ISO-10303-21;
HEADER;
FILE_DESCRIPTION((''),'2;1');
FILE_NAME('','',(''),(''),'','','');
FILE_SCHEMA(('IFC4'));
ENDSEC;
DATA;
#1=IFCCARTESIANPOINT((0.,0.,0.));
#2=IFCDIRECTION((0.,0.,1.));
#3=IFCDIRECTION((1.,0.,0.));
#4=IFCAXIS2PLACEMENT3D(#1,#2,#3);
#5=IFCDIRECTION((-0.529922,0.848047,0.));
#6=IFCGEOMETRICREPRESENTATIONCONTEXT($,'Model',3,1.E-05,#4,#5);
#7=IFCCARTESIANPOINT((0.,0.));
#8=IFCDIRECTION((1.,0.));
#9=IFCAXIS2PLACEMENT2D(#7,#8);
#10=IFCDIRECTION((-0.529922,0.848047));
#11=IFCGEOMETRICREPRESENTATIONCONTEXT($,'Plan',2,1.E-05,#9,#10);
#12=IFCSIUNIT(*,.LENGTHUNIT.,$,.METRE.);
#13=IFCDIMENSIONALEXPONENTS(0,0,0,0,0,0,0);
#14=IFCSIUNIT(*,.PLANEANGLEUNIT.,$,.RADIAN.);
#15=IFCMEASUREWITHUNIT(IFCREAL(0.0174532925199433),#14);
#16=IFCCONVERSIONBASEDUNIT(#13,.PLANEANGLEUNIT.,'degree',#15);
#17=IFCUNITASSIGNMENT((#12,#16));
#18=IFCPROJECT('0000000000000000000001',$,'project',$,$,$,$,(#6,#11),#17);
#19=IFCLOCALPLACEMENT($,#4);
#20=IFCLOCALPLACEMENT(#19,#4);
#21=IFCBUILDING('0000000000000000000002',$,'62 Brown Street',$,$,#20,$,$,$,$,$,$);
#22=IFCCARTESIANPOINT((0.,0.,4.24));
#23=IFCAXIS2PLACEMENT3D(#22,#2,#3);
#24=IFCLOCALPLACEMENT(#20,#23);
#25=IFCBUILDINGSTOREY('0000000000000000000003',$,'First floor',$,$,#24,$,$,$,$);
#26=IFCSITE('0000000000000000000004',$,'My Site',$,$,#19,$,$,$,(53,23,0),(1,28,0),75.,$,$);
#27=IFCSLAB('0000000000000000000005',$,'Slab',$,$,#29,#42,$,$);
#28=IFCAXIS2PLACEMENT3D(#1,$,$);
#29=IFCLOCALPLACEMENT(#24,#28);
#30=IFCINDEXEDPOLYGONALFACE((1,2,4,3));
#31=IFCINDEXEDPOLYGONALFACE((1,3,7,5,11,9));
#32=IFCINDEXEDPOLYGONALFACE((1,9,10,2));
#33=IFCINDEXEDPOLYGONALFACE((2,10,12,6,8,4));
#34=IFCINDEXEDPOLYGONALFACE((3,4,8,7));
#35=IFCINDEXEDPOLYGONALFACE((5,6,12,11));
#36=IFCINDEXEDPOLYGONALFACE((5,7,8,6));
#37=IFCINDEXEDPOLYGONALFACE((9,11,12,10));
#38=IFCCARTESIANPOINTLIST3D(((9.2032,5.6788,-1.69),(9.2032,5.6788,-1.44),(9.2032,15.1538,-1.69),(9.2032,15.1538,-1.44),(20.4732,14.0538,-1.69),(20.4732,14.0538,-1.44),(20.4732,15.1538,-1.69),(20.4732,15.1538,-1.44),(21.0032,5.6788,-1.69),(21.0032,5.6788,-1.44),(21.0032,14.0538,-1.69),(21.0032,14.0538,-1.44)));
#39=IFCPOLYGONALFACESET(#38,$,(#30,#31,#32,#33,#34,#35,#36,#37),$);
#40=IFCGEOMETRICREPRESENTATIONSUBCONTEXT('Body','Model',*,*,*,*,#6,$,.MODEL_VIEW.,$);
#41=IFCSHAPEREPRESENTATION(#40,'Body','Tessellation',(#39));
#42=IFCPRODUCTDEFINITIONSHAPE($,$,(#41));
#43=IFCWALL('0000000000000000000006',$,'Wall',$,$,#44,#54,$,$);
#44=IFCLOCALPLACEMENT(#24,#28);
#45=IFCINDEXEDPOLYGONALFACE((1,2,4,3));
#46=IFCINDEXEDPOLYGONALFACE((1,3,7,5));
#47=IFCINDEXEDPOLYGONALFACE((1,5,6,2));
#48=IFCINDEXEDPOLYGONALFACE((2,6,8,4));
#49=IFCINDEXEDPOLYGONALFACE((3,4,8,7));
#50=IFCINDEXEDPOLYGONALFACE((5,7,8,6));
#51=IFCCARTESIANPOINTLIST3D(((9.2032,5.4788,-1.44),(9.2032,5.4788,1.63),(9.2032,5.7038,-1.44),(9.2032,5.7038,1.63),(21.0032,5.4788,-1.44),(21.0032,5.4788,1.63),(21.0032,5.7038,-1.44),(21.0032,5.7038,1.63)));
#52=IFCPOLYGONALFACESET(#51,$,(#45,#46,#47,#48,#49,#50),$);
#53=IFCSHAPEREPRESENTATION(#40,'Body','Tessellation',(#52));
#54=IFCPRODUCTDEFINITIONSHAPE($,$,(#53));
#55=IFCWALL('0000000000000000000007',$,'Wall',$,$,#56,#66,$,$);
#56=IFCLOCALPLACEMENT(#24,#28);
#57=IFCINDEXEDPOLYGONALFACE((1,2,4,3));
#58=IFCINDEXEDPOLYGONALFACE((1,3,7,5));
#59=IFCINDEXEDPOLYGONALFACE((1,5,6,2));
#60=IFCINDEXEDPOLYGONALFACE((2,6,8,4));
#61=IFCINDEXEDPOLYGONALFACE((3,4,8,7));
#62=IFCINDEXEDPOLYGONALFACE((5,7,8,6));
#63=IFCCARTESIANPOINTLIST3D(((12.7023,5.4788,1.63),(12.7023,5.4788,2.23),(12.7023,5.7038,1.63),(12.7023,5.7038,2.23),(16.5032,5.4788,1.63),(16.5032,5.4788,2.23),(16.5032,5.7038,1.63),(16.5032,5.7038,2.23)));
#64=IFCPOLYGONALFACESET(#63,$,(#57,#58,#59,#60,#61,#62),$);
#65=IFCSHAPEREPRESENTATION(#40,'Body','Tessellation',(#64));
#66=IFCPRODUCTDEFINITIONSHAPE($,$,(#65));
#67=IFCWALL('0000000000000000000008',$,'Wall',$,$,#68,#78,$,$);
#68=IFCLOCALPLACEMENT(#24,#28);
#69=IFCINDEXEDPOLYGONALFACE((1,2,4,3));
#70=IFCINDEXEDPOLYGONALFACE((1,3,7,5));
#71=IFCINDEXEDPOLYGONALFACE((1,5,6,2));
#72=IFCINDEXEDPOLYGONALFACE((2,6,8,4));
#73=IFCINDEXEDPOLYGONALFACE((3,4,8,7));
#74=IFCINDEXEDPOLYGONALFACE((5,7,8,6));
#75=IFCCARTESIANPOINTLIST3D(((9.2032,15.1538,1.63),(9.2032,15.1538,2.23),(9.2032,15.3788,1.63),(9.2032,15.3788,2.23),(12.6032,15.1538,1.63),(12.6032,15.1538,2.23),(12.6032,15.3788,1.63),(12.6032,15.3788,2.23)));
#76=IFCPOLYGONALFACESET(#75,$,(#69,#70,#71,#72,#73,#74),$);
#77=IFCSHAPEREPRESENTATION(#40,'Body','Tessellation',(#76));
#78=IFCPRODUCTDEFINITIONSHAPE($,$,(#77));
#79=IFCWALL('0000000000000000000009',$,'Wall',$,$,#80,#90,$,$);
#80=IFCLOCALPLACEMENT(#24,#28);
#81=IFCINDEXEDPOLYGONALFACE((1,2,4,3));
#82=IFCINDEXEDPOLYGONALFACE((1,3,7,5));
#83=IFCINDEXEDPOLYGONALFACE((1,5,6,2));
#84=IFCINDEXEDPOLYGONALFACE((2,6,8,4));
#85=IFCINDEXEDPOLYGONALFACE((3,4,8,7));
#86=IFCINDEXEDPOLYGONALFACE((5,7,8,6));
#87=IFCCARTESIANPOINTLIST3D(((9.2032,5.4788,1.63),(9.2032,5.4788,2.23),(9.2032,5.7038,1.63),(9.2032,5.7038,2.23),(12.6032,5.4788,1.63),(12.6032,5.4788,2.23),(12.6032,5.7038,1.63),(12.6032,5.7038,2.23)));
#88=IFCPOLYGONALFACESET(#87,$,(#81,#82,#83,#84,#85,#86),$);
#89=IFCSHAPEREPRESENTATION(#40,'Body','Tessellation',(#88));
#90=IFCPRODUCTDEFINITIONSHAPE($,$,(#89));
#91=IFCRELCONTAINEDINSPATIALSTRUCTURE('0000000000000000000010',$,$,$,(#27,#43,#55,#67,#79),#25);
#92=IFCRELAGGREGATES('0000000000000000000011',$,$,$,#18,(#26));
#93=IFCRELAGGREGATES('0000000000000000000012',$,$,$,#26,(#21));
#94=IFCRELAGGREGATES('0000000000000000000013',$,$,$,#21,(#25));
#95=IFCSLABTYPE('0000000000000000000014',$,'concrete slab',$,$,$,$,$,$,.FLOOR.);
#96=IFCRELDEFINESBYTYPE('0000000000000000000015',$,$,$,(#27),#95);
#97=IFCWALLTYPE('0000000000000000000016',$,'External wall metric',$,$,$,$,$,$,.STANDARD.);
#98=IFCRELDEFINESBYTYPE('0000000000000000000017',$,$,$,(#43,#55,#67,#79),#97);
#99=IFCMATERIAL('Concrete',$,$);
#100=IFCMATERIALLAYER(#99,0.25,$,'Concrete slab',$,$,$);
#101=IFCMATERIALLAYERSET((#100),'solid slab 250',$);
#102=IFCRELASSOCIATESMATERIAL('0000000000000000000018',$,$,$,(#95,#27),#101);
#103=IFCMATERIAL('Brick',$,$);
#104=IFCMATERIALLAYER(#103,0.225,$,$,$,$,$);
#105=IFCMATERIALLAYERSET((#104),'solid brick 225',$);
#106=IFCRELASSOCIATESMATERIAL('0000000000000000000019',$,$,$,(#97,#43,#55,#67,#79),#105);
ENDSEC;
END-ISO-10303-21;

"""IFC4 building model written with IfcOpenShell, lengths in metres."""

from ifc_helpers import new_model, entity, si_unit, converted_unit, direction, frame, origin_with_axes, origin_2d_with_axis, place, context, subcontext, project, spatial, line, indexed_curve, outline, extrude, material, layer, layer_set, layer_usage, type_object, element, save


model = new_model("IFC4")

# Units and contexts
model_context = context("Model", 3, precision=1e-05, world=origin_with_axes(), true_north=direction((-0.529922, 0.848047, 0.0)))
plan_context = context("Plan", 2, precision=1e-05, world=origin_2d_with_axis(), true_north=direction((-0.529922, 0.848047)))
body_context_1 = subcontext(model_context, "Body", "Model", "MODEL_VIEW")
ifc_project = project(units=[si_unit("LENGTHUNIT", "METRE"), converted_unit("PLANEANGLEUNIT", "degree", entity("IfcReal", 0.0174532925199433), si_unit("PLANEANGLEUNIT", "RADIAN"), dimensions=[0, 0, 0, 0, 0, 0, 0])], contexts=[model_context, plan_context])

# Site, building, storey
site_placement = place(None, origin_with_axes())
site = spatial("IfcSite", under=ifc_project, at=site_placement, Name="My Site", RefLatitude=(53, 23, 0), RefLongitude=(1, 28, 0), RefElevation=75.0)
building_placement = place(site_placement, origin_with_axes())
building = spatial("IfcBuilding", under=site, at=building_placement, Name="62 Brown Street")
storey_placement = place(building_placement, frame((0.0, 0.0, 4.24), z_axis=(0.0, 0.0, 1.0), x_axis=(1.0, 0.0, 0.0)))
storey = spatial("IfcBuildingStorey", under=building, at=storey_placement, Name="First floor")

# Slab
ifc_material_1 = material(Name="Concrete")
ifc_layer_1 = layer(ifc_material_1, 0.25, Name="Concrete slab")
ifc_layer_set_1 = layer_set([ifc_layer_1], Name="solid slab 250")
ifc_layer_usage_1 = layer_usage(ifc_layer_set_1, "AXIS3", "POSITIVE", 0.0)
slab_type = type_object("IfcSlabType", Name="concrete slab", PredefinedType="FLOOR", material=ifc_layer_set_1)
slab_placement = place(storey_placement, frame((9.2032, 5.6788, -1.69), z_axis=(0.0, 0.0, 1.0), x_axis=(1.0, 0.0, 0.0)))
element("IfcSlab", 1, at=slab_placement, inside=storey, type_object=slab_type, material=ifc_layer_usage_1, Name="Slab", context=body_context_1, shape_type="SweptSolid", body=[
    extrude(outline(indexed_curve([(11.27, 9.475), (11.8, 0.0), (0.0, 0.0), (0.0, 9.475), (11.8, 8.375), (11.27, 8.375)], segments=[line(6, 1), line(1, 4), line(4, 3), line(3, 2), line(2, 5), line(5, 6)], self_intersect=False)), None, (0.0, 0.0, 1.0), 0.25),
])

# Walls
ifc_material_2 = material(Name="Brick")
ifc_layer_2 = layer(ifc_material_2, 0.225)
ifc_layer_set_2 = layer_set([ifc_layer_2], Name="solid brick 225")
ifc_layer_usage_2 = layer_usage(ifc_layer_set_2, "AXIS2", "POSITIVE", 0.0)
wall_type_1 = type_object("IfcWallType", Name="External wall metric", PredefinedType="STANDARD", material=ifc_layer_set_2)
wall_1_placement = place(storey_placement, frame((9.2032, 5.4788, -1.44), z_axis=(0.0, 0.0, 1.0), x_axis=(1.0, 0.0, 0.0)))
element("IfcWall", 2, at=wall_1_placement, inside=storey, type_object=wall_type_1, material=ifc_layer_usage_2, Name="Wall", context=body_context_1, shape_type="SweptSolid", body=[
    extrude(outline(indexed_curve([(0.0, 0.0), (0.0, 0.225), (11.8, 0.225), (11.8, 0.0), (0.0, 0.0)], self_intersect=False)), origin_with_axes(), (0.0, 0.0, 1.0), 3.07),
])
ifc_layer_usage_3 = layer_usage(ifc_layer_set_2, "AXIS2", "POSITIVE", 0.0)
wall_2_placement = place(storey_placement, frame((12.7023, 5.4788, 1.63), z_axis=(0.0, 0.0, 1.0), x_axis=(1.0, 0.0, 0.0)))
element("IfcWall", 3, at=wall_2_placement, inside=storey, type_object=wall_type_1, material=ifc_layer_usage_3, Name="Wall", context=body_context_1, shape_type="SweptSolid", body=[
    extrude(outline(indexed_curve([(0.0, 0.0), (0.0, 0.225), (3.8009, 0.225), (3.8009, 0.0), (0.0, 0.0)], self_intersect=False)), origin_with_axes(), (0.0, 0.0, 1.0), 0.6),
])
ifc_layer_usage_4 = layer_usage(ifc_layer_set_2, "AXIS2", "POSITIVE", 0.0)
wall_3_placement = place(storey_placement, frame((12.6032, 15.3788, 1.63), z_axis=(0.0, 0.0, 1.0), x_axis=(-1.0, 0.0, 0.0)))
element("IfcWall", 4, at=wall_3_placement, inside=storey, type_object=wall_type_1, material=ifc_layer_usage_4, Name="Wall", context=body_context_1, shape_type="SweptSolid", body=[
    extrude(outline(indexed_curve([(0.0, 0.0), (0.0, 0.225), (3.4, 0.225), (3.4, 0.0), (0.0, 0.0)], self_intersect=False)), origin_with_axes(), (0.0, 0.0, 1.0), 0.6),
])
ifc_layer_usage_5 = layer_usage(ifc_layer_set_2, "AXIS2", "POSITIVE", 0.0)
wall_4_placement = place(storey_placement, frame((9.2032, 5.4788, 1.63), z_axis=(0.0, 0.0, 1.0), x_axis=(1.0, 0.0, 0.0)))
element("IfcWall", 5, at=wall_4_placement, inside=storey, type_object=wall_type_1, material=ifc_layer_usage_5, Name="Wall", context=body_context_1, shape_type="SweptSolid", body=[
    extrude(outline(indexed_curve([(0.0, 0.0), (0.0, 0.225), (3.4, 0.225), (3.4, 0.0), (0.0, 0.0)], self_intersect=False)), origin_with_axes(), (0.0, 0.0, 1.0), 0.6),
])

save(model, "model.ifc")
